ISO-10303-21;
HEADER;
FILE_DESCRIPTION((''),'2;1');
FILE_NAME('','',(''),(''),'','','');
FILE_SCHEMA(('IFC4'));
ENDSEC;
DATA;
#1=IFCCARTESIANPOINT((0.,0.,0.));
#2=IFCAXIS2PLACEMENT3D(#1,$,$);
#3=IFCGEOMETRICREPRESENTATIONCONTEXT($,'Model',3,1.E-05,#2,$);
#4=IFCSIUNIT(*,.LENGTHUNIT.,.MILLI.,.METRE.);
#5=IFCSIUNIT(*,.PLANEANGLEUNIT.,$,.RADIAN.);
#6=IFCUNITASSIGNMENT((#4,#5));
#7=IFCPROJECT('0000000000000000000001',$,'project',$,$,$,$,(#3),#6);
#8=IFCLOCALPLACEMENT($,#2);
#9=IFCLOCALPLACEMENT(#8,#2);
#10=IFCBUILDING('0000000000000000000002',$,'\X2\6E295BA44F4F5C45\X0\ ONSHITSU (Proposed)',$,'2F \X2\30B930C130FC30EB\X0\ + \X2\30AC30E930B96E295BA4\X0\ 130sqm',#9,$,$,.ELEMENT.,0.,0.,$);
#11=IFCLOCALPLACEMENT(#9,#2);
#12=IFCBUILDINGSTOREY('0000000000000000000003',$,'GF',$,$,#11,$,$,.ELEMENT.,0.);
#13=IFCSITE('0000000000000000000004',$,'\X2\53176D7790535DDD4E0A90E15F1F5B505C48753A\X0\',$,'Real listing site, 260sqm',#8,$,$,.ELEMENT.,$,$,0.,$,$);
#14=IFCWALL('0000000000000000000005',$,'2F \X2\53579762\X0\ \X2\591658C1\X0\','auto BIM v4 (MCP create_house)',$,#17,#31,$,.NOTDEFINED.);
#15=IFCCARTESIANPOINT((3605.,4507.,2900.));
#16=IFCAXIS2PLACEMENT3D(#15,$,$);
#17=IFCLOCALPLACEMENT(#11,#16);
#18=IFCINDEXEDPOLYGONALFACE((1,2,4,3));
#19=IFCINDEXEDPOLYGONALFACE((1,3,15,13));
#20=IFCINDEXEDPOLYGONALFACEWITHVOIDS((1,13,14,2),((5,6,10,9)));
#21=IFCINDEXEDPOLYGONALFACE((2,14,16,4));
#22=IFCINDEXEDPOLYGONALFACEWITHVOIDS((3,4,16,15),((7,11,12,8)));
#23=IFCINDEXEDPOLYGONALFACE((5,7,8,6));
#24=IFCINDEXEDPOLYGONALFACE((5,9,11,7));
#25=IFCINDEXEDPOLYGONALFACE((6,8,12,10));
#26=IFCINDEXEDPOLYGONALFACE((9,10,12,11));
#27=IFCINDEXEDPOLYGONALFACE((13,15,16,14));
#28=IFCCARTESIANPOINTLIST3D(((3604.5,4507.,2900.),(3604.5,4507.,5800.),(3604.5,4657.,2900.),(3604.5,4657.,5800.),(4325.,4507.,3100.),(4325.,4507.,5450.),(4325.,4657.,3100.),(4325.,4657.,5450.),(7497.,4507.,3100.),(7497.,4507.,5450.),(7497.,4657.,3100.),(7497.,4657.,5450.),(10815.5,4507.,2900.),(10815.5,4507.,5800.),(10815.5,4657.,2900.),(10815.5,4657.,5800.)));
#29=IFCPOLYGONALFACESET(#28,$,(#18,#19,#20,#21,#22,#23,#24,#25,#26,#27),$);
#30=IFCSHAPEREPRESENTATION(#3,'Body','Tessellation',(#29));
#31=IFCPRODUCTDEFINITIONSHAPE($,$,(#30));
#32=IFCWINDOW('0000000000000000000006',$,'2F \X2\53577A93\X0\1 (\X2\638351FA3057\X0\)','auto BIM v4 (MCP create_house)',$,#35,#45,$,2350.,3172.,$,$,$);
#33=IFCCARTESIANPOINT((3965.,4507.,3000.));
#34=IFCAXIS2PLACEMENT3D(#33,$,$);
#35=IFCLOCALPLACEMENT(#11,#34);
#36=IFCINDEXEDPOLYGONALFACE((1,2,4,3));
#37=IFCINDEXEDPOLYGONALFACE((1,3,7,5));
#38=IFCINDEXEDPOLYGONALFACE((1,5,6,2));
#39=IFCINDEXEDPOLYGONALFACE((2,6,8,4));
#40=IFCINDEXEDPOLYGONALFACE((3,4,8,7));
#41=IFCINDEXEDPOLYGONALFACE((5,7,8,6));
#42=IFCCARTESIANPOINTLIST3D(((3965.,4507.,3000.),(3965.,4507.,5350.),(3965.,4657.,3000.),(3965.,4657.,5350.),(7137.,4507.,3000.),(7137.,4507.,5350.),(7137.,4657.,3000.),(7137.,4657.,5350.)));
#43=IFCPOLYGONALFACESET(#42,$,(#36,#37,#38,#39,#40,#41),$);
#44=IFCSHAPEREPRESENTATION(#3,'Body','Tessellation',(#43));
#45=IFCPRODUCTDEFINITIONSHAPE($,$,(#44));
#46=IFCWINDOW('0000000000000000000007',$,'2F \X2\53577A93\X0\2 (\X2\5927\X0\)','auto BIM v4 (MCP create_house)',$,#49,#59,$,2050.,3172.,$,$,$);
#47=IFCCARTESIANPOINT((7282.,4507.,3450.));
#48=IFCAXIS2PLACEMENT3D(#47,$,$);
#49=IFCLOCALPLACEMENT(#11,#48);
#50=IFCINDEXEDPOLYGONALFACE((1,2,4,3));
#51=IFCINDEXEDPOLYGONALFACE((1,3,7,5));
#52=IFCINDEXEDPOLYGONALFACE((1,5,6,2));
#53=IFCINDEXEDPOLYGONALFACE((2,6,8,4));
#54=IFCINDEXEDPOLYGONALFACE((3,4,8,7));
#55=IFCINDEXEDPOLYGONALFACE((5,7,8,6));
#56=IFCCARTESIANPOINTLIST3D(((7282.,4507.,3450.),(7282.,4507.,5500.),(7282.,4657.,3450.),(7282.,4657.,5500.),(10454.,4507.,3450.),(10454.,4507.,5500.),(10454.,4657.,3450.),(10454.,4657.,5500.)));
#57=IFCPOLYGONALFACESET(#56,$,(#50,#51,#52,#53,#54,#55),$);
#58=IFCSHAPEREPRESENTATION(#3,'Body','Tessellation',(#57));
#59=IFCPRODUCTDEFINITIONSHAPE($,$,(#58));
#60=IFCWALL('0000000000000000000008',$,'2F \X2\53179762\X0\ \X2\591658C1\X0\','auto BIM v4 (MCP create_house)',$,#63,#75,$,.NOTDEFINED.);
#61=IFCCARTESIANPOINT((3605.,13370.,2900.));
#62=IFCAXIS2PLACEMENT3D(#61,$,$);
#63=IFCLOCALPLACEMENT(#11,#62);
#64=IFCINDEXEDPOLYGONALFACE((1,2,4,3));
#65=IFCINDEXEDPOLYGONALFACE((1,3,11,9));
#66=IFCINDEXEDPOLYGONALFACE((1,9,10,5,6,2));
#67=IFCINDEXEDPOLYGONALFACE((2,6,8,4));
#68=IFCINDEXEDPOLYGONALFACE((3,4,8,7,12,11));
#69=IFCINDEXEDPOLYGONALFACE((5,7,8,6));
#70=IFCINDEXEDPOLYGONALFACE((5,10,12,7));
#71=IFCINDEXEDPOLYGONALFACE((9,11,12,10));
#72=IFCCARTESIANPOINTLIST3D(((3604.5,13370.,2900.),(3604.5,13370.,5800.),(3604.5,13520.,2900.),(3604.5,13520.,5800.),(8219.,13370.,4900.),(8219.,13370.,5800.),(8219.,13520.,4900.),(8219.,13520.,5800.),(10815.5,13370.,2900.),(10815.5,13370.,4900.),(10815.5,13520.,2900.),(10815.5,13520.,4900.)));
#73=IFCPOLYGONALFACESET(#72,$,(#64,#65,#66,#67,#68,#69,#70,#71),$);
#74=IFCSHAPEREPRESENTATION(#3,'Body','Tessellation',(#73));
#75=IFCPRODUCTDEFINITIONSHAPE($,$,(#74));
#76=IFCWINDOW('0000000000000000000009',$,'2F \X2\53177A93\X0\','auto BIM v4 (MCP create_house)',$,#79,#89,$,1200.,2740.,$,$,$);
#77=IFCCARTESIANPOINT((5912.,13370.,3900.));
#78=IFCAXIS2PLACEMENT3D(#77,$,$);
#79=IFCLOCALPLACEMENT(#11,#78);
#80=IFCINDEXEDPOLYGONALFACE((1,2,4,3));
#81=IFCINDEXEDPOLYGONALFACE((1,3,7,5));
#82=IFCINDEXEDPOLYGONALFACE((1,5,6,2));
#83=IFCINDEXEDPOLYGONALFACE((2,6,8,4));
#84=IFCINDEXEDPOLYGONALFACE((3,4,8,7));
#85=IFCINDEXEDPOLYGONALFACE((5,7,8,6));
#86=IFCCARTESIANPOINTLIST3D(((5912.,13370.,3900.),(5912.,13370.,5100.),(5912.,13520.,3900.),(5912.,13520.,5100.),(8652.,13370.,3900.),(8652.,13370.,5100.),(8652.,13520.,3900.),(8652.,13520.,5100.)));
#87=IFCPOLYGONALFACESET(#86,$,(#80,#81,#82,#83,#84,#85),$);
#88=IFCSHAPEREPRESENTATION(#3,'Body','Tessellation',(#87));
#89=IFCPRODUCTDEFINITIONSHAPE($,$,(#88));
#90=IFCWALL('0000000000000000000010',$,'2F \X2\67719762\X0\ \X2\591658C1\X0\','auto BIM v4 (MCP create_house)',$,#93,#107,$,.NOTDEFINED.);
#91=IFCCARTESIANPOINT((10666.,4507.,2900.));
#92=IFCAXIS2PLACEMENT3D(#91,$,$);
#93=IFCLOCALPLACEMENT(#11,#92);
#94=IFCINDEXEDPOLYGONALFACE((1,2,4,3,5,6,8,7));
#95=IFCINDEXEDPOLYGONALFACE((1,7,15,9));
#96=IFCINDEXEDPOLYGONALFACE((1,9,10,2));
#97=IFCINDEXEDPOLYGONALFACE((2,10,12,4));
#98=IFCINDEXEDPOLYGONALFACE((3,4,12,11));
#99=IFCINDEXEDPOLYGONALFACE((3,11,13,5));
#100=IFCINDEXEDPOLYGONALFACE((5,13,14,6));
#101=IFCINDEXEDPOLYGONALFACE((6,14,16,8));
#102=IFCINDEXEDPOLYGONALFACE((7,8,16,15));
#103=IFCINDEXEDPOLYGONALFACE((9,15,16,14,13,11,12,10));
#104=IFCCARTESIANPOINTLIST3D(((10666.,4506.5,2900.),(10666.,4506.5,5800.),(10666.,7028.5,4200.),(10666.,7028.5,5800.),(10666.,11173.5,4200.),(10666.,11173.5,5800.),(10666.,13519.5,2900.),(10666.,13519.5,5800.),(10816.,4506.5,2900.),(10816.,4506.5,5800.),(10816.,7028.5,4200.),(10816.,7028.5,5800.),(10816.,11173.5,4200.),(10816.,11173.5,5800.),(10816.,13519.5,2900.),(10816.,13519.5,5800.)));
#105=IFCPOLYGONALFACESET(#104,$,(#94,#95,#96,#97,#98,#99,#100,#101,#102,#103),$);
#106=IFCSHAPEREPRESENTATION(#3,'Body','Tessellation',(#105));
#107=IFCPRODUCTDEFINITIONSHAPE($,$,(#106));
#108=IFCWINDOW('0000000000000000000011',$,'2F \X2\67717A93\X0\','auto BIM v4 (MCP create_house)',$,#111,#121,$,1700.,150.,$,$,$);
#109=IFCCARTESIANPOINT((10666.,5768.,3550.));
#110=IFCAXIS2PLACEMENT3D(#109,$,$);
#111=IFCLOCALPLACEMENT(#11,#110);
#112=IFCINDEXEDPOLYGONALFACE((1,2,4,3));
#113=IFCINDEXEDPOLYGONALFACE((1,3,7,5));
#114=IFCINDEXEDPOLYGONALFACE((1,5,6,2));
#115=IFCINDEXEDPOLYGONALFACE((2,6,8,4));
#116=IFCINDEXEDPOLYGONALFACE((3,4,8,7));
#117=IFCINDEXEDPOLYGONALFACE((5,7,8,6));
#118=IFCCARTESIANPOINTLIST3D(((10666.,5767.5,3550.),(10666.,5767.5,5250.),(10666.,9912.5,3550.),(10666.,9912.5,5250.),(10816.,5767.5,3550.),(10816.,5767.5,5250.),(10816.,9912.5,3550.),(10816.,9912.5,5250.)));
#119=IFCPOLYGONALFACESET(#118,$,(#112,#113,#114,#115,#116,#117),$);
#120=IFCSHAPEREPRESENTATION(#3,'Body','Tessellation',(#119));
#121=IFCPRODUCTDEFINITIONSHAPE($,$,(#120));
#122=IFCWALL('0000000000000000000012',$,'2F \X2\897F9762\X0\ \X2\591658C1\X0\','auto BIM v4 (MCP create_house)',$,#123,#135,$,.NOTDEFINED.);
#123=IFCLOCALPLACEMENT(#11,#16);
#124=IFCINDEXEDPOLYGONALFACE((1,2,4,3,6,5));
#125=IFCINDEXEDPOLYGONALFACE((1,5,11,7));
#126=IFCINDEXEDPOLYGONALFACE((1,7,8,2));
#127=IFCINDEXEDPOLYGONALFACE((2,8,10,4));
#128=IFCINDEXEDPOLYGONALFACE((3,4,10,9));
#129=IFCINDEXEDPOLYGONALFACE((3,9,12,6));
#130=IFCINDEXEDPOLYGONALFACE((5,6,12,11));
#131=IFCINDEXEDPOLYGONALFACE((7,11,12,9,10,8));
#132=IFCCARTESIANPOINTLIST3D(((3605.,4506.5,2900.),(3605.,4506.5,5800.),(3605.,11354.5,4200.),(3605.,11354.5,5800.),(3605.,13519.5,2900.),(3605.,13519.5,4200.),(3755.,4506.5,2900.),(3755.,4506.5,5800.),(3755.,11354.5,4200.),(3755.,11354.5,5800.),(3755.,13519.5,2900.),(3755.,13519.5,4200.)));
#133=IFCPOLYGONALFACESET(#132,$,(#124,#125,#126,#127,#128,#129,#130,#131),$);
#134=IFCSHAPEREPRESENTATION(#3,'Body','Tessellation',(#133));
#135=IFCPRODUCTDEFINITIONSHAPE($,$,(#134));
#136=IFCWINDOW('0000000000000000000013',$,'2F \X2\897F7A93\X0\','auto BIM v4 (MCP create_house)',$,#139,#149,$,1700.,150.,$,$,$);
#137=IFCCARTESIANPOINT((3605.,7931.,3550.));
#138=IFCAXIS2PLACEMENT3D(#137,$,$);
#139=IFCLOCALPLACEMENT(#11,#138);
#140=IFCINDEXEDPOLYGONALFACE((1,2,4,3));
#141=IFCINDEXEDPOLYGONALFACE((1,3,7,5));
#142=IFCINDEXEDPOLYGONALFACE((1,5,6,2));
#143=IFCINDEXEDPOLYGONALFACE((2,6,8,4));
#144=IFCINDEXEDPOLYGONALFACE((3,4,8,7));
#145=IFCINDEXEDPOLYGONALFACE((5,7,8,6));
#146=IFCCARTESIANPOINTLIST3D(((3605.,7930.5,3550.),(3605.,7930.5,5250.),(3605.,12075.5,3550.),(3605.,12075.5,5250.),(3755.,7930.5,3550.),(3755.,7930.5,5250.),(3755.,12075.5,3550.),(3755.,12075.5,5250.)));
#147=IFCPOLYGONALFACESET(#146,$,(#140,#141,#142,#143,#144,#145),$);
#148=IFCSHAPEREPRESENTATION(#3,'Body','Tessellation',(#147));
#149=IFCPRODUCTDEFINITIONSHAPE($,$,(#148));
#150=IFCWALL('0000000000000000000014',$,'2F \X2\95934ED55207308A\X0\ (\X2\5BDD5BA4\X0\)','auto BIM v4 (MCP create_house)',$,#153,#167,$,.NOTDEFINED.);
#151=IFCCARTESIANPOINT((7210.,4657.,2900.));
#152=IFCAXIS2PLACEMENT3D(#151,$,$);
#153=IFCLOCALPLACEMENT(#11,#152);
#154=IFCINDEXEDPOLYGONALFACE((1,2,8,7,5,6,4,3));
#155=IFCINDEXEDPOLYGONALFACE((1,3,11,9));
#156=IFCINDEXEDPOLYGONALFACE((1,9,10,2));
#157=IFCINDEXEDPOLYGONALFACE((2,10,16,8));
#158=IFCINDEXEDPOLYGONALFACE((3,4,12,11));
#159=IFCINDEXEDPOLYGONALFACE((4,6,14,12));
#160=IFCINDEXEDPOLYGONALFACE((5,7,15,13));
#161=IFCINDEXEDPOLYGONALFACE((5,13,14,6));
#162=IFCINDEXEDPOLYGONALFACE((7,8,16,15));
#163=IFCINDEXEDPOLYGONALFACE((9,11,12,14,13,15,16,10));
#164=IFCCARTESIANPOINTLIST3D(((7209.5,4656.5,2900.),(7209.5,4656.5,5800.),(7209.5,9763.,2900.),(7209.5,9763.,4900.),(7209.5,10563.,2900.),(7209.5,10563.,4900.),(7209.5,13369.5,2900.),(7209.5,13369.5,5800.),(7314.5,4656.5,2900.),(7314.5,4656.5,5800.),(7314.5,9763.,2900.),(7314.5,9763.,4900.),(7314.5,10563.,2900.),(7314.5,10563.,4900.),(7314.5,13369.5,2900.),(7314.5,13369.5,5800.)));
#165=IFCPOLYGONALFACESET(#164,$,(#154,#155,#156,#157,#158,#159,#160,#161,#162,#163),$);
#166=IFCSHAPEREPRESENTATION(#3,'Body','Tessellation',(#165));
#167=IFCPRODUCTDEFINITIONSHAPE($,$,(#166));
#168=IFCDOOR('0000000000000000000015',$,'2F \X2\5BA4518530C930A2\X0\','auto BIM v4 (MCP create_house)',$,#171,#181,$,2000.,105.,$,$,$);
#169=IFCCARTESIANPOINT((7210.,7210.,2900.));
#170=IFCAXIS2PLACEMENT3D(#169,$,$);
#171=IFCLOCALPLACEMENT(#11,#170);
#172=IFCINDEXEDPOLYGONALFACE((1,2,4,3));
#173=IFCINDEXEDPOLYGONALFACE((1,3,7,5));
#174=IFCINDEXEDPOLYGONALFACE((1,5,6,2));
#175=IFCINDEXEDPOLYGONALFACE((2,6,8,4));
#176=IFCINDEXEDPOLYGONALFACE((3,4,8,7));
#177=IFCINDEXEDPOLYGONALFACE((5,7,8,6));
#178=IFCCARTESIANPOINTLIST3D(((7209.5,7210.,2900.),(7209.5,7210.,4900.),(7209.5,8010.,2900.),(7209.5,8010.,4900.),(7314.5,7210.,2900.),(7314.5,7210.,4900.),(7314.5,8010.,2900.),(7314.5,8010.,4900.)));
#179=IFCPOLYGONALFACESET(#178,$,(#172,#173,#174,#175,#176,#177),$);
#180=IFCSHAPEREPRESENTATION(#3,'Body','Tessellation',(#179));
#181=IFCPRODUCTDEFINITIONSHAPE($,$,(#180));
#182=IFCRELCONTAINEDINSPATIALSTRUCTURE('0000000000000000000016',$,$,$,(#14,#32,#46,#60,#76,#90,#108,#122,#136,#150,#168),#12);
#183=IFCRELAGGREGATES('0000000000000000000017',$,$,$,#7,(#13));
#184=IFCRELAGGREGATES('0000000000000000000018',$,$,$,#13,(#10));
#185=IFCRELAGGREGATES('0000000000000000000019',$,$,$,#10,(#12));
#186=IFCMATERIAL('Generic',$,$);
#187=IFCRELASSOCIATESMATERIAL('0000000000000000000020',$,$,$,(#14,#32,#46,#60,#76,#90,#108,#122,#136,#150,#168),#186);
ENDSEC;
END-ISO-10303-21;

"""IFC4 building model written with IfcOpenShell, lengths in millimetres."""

from ifc_helpers import new_model, si_unit, frame, frame_2d, origin, place, context, project, spatial, rectangle, extrude, material, element, fill, save


model = new_model("IFC4")

# Units and contexts
model_context = context("Model", 3, precision=1e-05, world=origin())
ifc_project = project(units=[si_unit("LENGTHUNIT", "METRE", prefix="MILLI"), si_unit("PLANEANGLEUNIT", "RADIAN")], contexts=[model_context])

# Site, building, storey
site_placement = place(None, origin())
site = spatial("IfcSite", under=ifc_project, at=site_placement, Name="北海道川上郡弟子屈町", ObjectType="Real listing site, 260sqm", CompositionType="ELEMENT", RefElevation=0.0)
building_placement = place(site_placement, origin())
building = spatial("IfcBuilding", under=site, at=building_placement, Name="温室住居 ONSHITSU (Proposed)", ObjectType="2F スチール + ガラス温室 130sqm", CompositionType="ELEMENT", ElevationOfRefHeight=0.0, ElevationOfTerrain=0.0)
storey_placement = place(building_placement, origin())
storey = spatial("IfcBuildingStorey", under=building, at=storey_placement, Name="GF", CompositionType="ELEMENT", Elevation=0.0)

# Shared definitions
ifc_material = material(Name="Generic")

# Wall, openings, windows
wall_1_placement = place(storey_placement, frame((3605.0, 4507.0, 2900.0)))
wall_1 = element("IfcWall", 1, at=wall_1_placement, inside=storey, material=ifc_material, Name="2F 南面 外壁", Description="auto BIM v4 (MCP create_house)", PredefinedType="NOTDEFINED", context=model_context, shape_type="SweptSolid", body=[
    extrude(rectangle(XDim=7211.0, YDim=150.0, at=frame_2d((3605.0, 75.0))), frame((3605.0, 4507.0, 2900.0)), (0.0, 0.0, 1.0), 2900.0),
])
opening_1_placement = place(storey_placement, frame((3965.0, 4507.0, 3000.0)))
opening_1 = element("IfcOpeningElement", 2, at=opening_1_placement, cuts=wall_1, PredefinedType="NOTDEFINED", context=model_context, shape_type="SweptSolid", body=[
    extrude(rectangle(XDim=3172.0, YDim=150.0, at=frame_2d((1586.0, 75.0))), frame((3965.0, 4507.0, 3000.0)), (0.0, 0.0, 1.0), 2350.0),
])
opening_2_placement = place(storey_placement, frame((7282.0, 4507.0, 3450.0)))
opening_2 = element("IfcOpeningElement", 3, at=opening_2_placement, cuts=wall_1, PredefinedType="NOTDEFINED", context=model_context, shape_type="SweptSolid", body=[
    extrude(rectangle(XDim=3172.0, YDim=150.0, at=frame_2d((1586.0, 75.0))), frame((7282.0, 4507.0, 3450.0)), (0.0, 0.0, 1.0), 2050.0),
])
window_1_placement = place(storey_placement, frame((3965.0, 4507.0, 3000.0)))
window_1 = element("IfcWindow", 4, at=window_1_placement, inside=storey, material=ifc_material, Name="2F 南窓1 (掃出し)", Description="auto BIM v4 (MCP create_house)", OverallHeight=2350.0, OverallWidth=3172.0, context=model_context, shape_type="SweptSolid", body=[
    extrude(rectangle(XDim=3172.0, YDim=150.0, at=frame_2d((1586.0, 75.0))), frame((3965.0, 4507.0, 3000.0)), (0.0, 0.0, 1.0), 2350.0),
])
fill(opening_1, window_1)
window_2_placement = place(storey_placement, frame((7282.0, 4507.0, 3450.0)))
window_2 = element("IfcWindow", 5, at=window_2_placement, inside=storey, material=ifc_material, Name="2F 南窓2 (大)", Description="auto BIM v4 (MCP create_house)", OverallHeight=2050.0, OverallWidth=3172.0, context=model_context, shape_type="SweptSolid", body=[
    extrude(rectangle(XDim=3172.0, YDim=150.0, at=frame_2d((1586.0, 75.0))), frame((7282.0, 4507.0, 3450.0)), (0.0, 0.0, 1.0), 2050.0),
])
fill(opening_2, window_2)

# Walls, openings, windows
wall_2_placement = place(storey_placement, frame((3605.0, 13370.0, 2900.0)))
wall_2 = element("IfcWall", 6, at=wall_2_placement, inside=storey, material=ifc_material, Name="2F 北面 外壁", Description="auto BIM v4 (MCP create_house)", PredefinedType="NOTDEFINED", context=model_context, shape_type="SweptSolid", body=[
    extrude(rectangle(XDim=7211.0, YDim=150.0, at=frame_2d((3605.0, 75.0))), frame((3605.0, 13370.0, 2900.0)), (0.0, 0.0, 1.0), 2900.0),
])
opening_3_placement = place(storey_placement, frame((5912.0, 13370.0, 3900.0)))
opening_3 = element("IfcOpeningElement", 7, at=opening_3_placement, cuts=wall_2, PredefinedType="NOTDEFINED", context=model_context, shape_type="SweptSolid", body=[
    extrude(rectangle(XDim=2740.0, YDim=150.0, at=frame_2d((1370.0, 75.0))), frame((5912.0, 13370.0, 3900.0)), (0.0, 0.0, 1.0), 1200.0),
])
window_3_placement = place(storey_placement, frame((5912.0, 13370.0, 3900.0)))
window_3 = element("IfcWindow", 8, at=window_3_placement, inside=storey, material=ifc_material, Name="2F 北窓", Description="auto BIM v4 (MCP create_house)", OverallHeight=1200.0, OverallWidth=2740.0, context=model_context, shape_type="SweptSolid", body=[
    extrude(rectangle(XDim=2740.0, YDim=150.0, at=frame_2d((1370.0, 75.0))), frame((5912.0, 13370.0, 3900.0)), (0.0, 0.0, 1.0), 1200.0),
])
fill(opening_3, window_3)
wall_3_placement = place(storey_placement, frame((10666.0, 4507.0, 2900.0)))
wall_3 = element("IfcWall", 9, at=wall_3_placement, inside=storey, material=ifc_material, Name="2F 東面 外壁", Description="auto BIM v4 (MCP create_house)", PredefinedType="NOTDEFINED", context=model_context, shape_type="SweptSolid", body=[
    extrude(rectangle(XDim=150.0, YDim=9013.0, at=frame_2d((75.0, 4506.0))), frame((10666.0, 4507.0, 2900.0)), (0.0, 0.0, 1.0), 2900.0),
])
opening_4_placement = place(storey_placement, frame((10666.0, 5768.0, 3550.0)))
opening_4 = element("IfcOpeningElement", 10, at=opening_4_placement, cuts=wall_3, PredefinedType="NOTDEFINED", context=model_context, shape_type="SweptSolid", body=[
    extrude(rectangle(XDim=150.0, YDim=4145.0, at=frame_2d((75.0, 2072.0))), frame((10666.0, 5768.0, 3550.0)), (0.0, 0.0, 1.0), 1700.0),
])
window_4_placement = place(storey_placement, frame((10666.0, 5768.0, 3550.0)))
window_4 = element("IfcWindow", 11, at=window_4_placement, inside=storey, material=ifc_material, Name="2F 東窓", Description="auto BIM v4 (MCP create_house)", OverallHeight=1700.0, OverallWidth=150.0, context=model_context, shape_type="SweptSolid", body=[
    extrude(rectangle(XDim=150.0, YDim=4145.0, at=frame_2d((75.0, 2072.0))), frame((10666.0, 5768.0, 3550.0)), (0.0, 0.0, 1.0), 1700.0),
])
fill(opening_4, window_4)
wall_4_placement = place(storey_placement, frame((3605.0, 4507.0, 2900.0)))
wall_4 = element("IfcWall", 12, at=wall_4_placement, inside=storey, material=ifc_material, Name="2F 西面 外壁", Description="auto BIM v4 (MCP create_house)", PredefinedType="NOTDEFINED", context=model_context, shape_type="SweptSolid", body=[
    extrude(rectangle(XDim=150.0, YDim=9013.0, at=frame_2d((75.0, 4506.0))), frame((3605.0, 4507.0, 2900.0)), (0.0, 0.0, 1.0), 2900.0),
])
opening_5_placement = place(storey_placement, frame((3605.0, 7931.0, 3550.0)))
opening_5 = element("IfcOpeningElement", 13, at=opening_5_placement, cuts=wall_4, PredefinedType="NOTDEFINED", context=model_context, shape_type="SweptSolid", body=[
    extrude(rectangle(XDim=150.0, YDim=4145.0, at=frame_2d((75.0, 2072.0))), frame((3605.0, 7931.0, 3550.0)), (0.0, 0.0, 1.0), 1700.0),
])
window_5_placement = place(storey_placement, frame((3605.0, 7931.0, 3550.0)))
window_5 = element("IfcWindow", 14, at=window_5_placement, inside=storey, material=ifc_material, Name="2F 西窓", Description="auto BIM v4 (MCP create_house)", OverallHeight=1700.0, OverallWidth=150.0, context=model_context, shape_type="SweptSolid", body=[
    extrude(rectangle(XDim=150.0, YDim=4145.0, at=frame_2d((75.0, 2072.0))), frame((3605.0, 7931.0, 3550.0)), (0.0, 0.0, 1.0), 1700.0),
])
fill(opening_5, window_5)

# Wall, opening, door
wall_5_placement = place(storey_placement, frame((7210.0, 4657.0, 2900.0)))
wall_5 = element("IfcWall", 15, at=wall_5_placement, inside=storey, material=ifc_material, Name="2F 間仕切り (寝室)", Description="auto BIM v4 (MCP create_house)", PredefinedType="NOTDEFINED", context=model_context, shape_type="SweptSolid", body=[
    extrude(rectangle(XDim=105.0, YDim=8713.0, at=frame_2d((52.0, 4356.0))), frame((7210.0, 4657.0, 2900.0)), (0.0, 0.0, 1.0), 2900.0),
])
opening_6_placement = place(storey_placement, frame((7210.0, 7210.0, 2900.0)))
opening_6 = element("IfcOpeningElement", 16, at=opening_6_placement, cuts=wall_5, PredefinedType="NOTDEFINED", context=model_context, shape_type="SweptSolid", body=[
    extrude(rectangle(XDim=105.0, YDim=800.0, at=frame_2d((52.0, 400.0))), frame((7210.0, 7210.0, 2900.0)), (0.0, 0.0, 1.0), 2000.0),
])
door_1_placement = place(storey_placement, frame((7210.0, 7210.0, 2900.0)))
door_1 = element("IfcDoor", 17, at=door_1_placement, inside=storey, material=ifc_material, Name="2F 室内ドア", Description="auto BIM v4 (MCP create_house)", OverallHeight=2000.0, OverallWidth=105.0, context=model_context, shape_type="SweptSolid", body=[
    extrude(rectangle(XDim=105.0, YDim=800.0, at=frame_2d((52.0, 400.0))), frame((7210.0, 7210.0, 2900.0)), (0.0, 0.0, 1.0), 2000.0),
])
fill(opening_6, door_1)

save(model, "model.ifc")
